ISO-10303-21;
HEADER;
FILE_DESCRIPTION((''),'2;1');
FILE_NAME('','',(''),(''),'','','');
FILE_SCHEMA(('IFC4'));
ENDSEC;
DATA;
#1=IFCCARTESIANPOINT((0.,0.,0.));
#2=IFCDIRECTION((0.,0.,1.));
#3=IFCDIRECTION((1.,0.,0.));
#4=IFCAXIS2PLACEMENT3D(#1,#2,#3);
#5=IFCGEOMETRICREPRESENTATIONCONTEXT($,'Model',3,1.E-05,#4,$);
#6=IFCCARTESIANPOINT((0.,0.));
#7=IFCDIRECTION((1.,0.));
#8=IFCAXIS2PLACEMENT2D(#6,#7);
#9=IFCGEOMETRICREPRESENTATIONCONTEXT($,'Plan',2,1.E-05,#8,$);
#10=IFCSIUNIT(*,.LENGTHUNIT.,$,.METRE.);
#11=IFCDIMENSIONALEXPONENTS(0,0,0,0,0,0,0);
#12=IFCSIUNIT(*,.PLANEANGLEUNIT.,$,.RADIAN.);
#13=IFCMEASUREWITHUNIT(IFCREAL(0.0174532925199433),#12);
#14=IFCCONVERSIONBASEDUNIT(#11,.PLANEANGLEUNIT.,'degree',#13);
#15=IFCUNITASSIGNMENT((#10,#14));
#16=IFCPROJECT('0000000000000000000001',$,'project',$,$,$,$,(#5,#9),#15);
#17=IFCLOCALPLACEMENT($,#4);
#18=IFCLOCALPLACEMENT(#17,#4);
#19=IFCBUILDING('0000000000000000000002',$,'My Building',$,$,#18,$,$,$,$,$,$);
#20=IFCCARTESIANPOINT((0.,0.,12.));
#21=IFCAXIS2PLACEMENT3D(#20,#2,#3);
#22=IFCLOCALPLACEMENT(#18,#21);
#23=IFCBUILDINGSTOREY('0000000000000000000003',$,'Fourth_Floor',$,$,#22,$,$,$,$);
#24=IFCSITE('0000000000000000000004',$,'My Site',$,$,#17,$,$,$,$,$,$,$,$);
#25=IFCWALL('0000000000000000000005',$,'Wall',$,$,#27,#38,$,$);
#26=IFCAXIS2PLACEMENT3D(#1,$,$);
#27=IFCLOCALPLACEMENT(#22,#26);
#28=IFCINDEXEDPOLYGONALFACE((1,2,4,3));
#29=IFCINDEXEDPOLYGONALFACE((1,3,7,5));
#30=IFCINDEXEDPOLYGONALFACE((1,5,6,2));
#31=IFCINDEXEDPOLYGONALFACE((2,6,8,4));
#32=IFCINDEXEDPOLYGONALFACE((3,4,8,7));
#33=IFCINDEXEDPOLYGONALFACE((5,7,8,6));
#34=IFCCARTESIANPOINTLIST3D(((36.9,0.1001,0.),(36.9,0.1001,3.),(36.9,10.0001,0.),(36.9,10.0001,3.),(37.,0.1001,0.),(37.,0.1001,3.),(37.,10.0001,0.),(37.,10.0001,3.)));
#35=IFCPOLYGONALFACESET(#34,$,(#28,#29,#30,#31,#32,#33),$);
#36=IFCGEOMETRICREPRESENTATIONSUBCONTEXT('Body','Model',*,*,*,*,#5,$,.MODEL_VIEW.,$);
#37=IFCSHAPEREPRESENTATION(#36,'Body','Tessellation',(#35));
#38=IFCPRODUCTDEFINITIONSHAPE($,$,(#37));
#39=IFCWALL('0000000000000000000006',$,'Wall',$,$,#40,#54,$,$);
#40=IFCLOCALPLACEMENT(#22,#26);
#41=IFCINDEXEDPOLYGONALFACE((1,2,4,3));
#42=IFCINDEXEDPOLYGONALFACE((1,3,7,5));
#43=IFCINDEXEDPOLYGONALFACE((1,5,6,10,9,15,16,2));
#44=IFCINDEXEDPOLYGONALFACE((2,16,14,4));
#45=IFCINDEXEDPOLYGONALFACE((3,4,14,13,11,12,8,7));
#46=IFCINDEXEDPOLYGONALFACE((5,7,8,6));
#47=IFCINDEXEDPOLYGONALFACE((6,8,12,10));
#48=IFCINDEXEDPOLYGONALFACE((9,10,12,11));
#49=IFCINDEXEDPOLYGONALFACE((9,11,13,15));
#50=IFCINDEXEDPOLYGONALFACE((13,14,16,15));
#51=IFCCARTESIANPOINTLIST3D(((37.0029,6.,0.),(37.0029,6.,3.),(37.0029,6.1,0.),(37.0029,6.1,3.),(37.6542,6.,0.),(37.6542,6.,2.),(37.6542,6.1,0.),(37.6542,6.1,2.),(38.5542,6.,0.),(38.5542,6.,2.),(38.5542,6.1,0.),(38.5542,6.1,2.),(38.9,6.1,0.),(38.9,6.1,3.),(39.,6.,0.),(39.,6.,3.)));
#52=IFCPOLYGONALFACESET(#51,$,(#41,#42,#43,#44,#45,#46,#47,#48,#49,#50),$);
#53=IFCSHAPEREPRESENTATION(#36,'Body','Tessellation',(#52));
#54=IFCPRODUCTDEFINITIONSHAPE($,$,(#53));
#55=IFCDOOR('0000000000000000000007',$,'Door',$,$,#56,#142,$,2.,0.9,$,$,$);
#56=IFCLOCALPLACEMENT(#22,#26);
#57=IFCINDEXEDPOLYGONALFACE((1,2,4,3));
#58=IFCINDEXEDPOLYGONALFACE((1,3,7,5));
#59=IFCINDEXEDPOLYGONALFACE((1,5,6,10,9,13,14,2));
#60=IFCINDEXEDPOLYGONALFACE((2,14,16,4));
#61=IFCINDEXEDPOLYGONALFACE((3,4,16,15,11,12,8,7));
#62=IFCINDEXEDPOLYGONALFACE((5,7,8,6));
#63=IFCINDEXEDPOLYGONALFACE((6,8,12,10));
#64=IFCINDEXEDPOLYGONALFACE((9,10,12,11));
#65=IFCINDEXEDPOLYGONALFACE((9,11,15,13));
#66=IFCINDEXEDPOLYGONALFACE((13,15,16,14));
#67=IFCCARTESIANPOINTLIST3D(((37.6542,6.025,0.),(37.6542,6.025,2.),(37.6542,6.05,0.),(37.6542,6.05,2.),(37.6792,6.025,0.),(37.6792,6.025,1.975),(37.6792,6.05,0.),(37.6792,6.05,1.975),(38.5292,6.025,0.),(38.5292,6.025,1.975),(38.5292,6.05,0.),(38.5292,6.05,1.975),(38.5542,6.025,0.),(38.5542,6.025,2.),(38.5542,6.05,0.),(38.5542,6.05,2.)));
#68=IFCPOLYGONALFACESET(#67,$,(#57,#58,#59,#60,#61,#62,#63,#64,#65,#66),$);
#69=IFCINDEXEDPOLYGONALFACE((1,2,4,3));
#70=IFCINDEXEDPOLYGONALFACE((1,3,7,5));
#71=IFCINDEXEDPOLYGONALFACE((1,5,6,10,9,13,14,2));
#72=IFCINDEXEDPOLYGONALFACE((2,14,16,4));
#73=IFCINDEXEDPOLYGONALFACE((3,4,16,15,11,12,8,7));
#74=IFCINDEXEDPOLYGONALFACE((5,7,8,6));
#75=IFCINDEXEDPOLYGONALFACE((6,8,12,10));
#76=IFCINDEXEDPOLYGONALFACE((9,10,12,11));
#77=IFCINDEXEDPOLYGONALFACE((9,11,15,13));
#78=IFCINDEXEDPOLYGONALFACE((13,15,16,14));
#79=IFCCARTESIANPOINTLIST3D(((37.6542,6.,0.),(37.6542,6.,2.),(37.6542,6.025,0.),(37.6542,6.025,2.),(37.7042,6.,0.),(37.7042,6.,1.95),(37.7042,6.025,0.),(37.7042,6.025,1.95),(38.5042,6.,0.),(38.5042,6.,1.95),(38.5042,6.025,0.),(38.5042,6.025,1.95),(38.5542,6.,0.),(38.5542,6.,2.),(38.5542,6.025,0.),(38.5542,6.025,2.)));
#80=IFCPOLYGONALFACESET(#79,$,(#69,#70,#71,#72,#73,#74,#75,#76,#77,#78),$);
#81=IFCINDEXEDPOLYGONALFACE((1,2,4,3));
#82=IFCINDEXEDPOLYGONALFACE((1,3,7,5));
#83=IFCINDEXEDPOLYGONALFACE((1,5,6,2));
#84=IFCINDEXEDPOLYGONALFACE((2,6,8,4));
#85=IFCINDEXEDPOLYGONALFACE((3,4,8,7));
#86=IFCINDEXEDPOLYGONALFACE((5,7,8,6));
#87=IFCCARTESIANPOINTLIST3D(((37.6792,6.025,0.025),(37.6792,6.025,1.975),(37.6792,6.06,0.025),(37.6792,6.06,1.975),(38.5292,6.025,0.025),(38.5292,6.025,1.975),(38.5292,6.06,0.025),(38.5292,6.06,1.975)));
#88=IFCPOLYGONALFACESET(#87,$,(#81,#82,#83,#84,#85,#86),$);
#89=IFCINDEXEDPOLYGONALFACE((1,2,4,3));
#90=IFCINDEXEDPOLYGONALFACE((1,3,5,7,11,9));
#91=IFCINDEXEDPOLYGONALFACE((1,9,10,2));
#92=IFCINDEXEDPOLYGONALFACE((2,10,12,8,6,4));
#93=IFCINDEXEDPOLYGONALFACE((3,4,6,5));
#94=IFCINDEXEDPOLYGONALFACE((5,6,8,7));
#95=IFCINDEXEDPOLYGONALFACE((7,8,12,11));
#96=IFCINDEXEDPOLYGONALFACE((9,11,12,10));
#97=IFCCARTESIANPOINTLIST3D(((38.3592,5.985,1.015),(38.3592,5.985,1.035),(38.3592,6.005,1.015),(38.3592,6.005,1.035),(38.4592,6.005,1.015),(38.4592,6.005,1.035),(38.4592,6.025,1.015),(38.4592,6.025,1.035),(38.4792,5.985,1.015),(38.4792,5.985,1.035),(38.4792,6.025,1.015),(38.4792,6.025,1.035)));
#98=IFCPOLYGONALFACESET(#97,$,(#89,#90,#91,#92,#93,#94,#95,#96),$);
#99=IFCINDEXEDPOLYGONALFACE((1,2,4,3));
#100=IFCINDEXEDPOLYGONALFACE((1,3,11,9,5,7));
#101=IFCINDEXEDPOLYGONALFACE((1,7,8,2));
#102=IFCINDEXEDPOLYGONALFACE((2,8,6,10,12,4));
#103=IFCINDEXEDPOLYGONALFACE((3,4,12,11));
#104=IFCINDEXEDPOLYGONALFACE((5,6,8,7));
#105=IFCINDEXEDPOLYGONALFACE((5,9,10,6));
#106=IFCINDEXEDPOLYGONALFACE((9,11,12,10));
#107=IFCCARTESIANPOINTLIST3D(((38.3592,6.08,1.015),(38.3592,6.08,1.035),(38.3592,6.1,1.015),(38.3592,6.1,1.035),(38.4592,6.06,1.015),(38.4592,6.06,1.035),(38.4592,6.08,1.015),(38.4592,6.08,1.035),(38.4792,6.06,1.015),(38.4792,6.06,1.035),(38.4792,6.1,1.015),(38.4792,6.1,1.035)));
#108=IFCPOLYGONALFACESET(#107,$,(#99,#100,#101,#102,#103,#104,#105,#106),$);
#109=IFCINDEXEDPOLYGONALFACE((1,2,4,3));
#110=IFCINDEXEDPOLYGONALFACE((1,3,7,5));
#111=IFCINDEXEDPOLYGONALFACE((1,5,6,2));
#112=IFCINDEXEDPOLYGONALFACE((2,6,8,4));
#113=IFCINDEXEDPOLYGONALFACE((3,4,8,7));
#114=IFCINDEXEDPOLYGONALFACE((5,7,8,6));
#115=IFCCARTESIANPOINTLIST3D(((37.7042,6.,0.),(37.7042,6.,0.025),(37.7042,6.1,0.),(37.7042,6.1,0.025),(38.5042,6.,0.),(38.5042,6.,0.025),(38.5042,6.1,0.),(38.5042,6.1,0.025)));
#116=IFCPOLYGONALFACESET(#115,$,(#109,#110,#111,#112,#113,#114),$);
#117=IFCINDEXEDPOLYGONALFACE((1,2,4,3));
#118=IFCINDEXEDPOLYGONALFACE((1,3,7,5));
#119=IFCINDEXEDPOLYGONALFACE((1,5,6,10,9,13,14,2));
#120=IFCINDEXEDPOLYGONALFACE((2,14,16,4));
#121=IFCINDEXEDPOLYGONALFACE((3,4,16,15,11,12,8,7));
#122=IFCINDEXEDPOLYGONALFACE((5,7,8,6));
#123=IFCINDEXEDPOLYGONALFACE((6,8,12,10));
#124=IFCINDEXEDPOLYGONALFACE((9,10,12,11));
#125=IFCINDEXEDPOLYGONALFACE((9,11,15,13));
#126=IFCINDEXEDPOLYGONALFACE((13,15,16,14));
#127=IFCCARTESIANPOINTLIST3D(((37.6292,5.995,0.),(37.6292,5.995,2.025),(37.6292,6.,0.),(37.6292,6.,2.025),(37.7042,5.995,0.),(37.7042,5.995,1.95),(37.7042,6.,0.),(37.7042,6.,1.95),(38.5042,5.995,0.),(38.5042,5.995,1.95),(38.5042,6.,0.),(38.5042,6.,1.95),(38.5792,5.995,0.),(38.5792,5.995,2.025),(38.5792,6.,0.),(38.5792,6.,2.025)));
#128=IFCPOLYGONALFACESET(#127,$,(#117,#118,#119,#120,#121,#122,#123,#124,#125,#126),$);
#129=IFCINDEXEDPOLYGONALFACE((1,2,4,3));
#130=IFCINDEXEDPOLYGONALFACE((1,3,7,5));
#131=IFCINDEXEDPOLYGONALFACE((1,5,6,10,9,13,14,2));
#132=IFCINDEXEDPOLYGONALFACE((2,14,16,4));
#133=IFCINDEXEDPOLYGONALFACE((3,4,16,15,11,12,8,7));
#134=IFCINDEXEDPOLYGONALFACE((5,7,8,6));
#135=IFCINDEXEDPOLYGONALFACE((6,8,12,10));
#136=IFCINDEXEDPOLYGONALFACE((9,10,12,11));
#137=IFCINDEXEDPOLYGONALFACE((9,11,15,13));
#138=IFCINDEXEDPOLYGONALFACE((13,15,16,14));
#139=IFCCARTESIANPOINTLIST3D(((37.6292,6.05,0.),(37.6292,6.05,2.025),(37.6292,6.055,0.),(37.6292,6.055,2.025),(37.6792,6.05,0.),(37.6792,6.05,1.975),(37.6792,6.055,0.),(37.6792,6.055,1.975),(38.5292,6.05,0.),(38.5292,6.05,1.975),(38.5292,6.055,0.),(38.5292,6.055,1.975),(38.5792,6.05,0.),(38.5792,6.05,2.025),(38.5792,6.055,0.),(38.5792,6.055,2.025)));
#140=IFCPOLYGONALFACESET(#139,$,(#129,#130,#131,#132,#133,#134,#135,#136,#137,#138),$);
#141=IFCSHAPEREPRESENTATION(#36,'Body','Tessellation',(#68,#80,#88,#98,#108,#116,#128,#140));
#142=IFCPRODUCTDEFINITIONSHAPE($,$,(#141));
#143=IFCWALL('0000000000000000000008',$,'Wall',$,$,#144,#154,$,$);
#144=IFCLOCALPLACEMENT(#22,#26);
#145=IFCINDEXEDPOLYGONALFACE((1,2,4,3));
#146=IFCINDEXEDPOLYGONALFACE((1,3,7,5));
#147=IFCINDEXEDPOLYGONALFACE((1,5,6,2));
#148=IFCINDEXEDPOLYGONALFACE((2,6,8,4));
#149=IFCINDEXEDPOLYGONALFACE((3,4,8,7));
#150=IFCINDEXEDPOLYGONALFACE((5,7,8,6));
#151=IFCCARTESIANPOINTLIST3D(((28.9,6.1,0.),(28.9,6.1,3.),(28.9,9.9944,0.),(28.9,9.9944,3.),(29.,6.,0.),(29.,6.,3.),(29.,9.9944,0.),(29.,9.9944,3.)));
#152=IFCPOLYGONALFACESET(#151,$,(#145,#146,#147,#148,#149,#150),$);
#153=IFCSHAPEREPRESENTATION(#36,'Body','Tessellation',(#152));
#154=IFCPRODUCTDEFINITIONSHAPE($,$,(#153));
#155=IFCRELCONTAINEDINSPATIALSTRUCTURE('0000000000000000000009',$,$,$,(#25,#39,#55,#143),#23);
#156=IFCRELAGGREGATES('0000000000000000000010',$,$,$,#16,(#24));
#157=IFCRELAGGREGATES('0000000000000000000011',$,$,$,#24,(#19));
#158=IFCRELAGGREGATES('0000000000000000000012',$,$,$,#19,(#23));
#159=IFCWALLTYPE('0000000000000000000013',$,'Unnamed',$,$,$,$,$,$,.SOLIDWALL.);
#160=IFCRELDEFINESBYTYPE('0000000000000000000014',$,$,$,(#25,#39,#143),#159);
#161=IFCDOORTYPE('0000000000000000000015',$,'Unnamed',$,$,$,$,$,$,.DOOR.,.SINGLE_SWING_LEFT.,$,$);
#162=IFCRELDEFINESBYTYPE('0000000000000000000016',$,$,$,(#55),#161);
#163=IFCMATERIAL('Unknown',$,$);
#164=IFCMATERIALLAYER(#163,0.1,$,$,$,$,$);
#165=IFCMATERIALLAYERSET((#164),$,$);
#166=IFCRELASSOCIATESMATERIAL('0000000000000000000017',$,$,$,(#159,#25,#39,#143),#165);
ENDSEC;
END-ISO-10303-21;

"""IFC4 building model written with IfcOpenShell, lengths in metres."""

from ifc_helpers import new_model, entity, si_unit, converted_unit, frame, origin_with_axes, origin_2d_with_axis, place, context, subcontext, project, spatial, line, indexed_curve, outline, extrude, shape, source, transform, mapped, material, layer, layer_set, layer_usage, type_object, type_shapes, element, fill, save


model = new_model("IFC4")

# Units and contexts
model_context = context("Model", 3, precision=1e-05, world=origin_with_axes())
plan_context = context("Plan", 2, precision=1e-05, world=origin_2d_with_axis())
body_context_1 = subcontext(model_context, "Body", "Model", "MODEL_VIEW")
body_context_2 = subcontext(plan_context, "Body", "Plan", "PLAN_VIEW")
ifc_project = project(units=[si_unit("LENGTHUNIT", "METRE"), converted_unit("PLANEANGLEUNIT", "degree", entity("IfcReal", 0.0174532925199433), si_unit("PLANEANGLEUNIT", "RADIAN"), dimensions=[0, 0, 0, 0, 0, 0, 0])], contexts=[model_context, plan_context])

# Site, building, storey
site_placement = place(None, origin_with_axes())
site = spatial("IfcSite", under=ifc_project, at=site_placement, Name="My Site")
building_placement = place(site_placement, origin_with_axes())
building = spatial("IfcBuilding", under=site, at=building_placement, Name="My Building")
storey_placement = place(building_placement, frame((0.0, 0.0, 12.0), z_axis=(0.0, 0.0, 1.0), x_axis=(1.0, 0.0, 0.0)))
storey = spatial("IfcBuildingStorey", under=building, at=storey_placement, Name="Fourth_Floor")

# Shared definitions
ifc_material = material(Name="Unknown")
ifc_layer = layer(ifc_material, 0.1)
ifc_layer_set = layer_set([ifc_layer])
wall_type = type_object("IfcWallType", Name="Unnamed", PredefinedType="SOLIDWALL", material=ifc_layer_set)

# Shared definitions
shared_shape_1 = source(origin_with_axes(), body_context_1, "Body", "SweptSolid", [
    extrude(outline(indexed_curve([(0.0, 0.0), (0.9, 0.0), (0.9, 2.0), (0.0, 2.0)], segments=[line(1, 2, 3, 4, 1)])), frame((0.0, -0.6, 0.0), z_axis=(0.0, -1.0, 0.0), x_axis=(1.0, 0.0, 0.0)), (0.0, 0.0, -1.0), 1.2),
])
door_type = type_object("IfcDoorType", Name="Unnamed", OperationType="SINGLE_SWING_LEFT", PredefinedType="DOOR")
shared_shape_2 = source(origin_with_axes(), body_context_1, "Body", "SweptSolid", [
    extrude(outline(indexed_curve([(0.0, 0.0), (0.0, 2.0), (0.9, 2.0), (0.9, 0.0), (0.875, 0.0), (0.875, 1.975), (0.025, 1.975), (0.025, 0.0)], segments=[line(1, 2, 3, 4, 5, 6, 7, 8, 1)])), frame((0.0, 0.025, 0.0), z_axis=(0.0, -1.0, 0.0), x_axis=(1.0, 0.0, 0.0)), (0.0, 0.0, -1.0), 0.025),
    extrude(outline(indexed_curve([(0.0, 0.0), (0.0, 2.0), (0.9, 2.0), (0.9, 0.0), (0.85, 0.0), (0.85, 1.95), (0.05, 1.95), (0.05, 0.0)], segments=[line(1, 2, 3, 4, 5, 6, 7, 8, 1)])), frame((0.0, 0.0, 0.0), z_axis=(0.0, -1.0, 0.0), x_axis=(1.0, 0.0, 0.0)), (0.0, 0.0, -1.0), 0.025),
    extrude(outline(indexed_curve([(0.0, 0.0), (0.85, 0.0), (0.85, 0.035), (0.0, 0.035)], segments=[line(1, 2, 3, 4, 1)])), frame((0.025, 0.025, 0.025), z_axis=(0.0, 0.0, 1.0), x_axis=(1.0, 0.0, 0.0)), (0.0, 0.0, 1.0), 1.95),
    extrude(outline(indexed_curve([(0.0, 0.0), (0.0, -0.04), (-0.12, -0.04), (-0.12, -0.02), (-0.02, -0.02), (-0.02, 0.0)], segments=[line(1, 2, 3, 4, 5, 6, 1)])), frame((0.825, 0.025, 1.015), z_axis=(0.0, 0.0, 1.0), x_axis=(1.0, 0.0, 0.0)), (0.0, 0.0, 1.0), 0.02),
    extrude(outline(indexed_curve([(0.0, 0.0), (0.0, 0.04), (-0.12, 0.04), (-0.12, 0.02), (-0.02, 0.02), (-0.02, 0.0)], segments=[line(1, 2, 3, 4, 5, 6, 1)])), frame((0.825, 0.06, 1.015), z_axis=(0.0, 0.0, 1.0), x_axis=(1.0, 0.0, 0.0)), (0.0, 0.0, 1.0), 0.02),
    extrude(outline(indexed_curve([(0.0, 0.0), (0.8, 0.0), (0.8, 0.1), (0.0, 0.1)], segments=[line(1, 2, 3, 4, 1)])), frame((0.05, 0.0, 0.0), z_axis=(0.0, 0.0, 1.0), x_axis=(1.0, 0.0, 0.0)), (0.0, 0.0, 1.0), 0.025),
    extrude(outline(indexed_curve([(0.0, 0.0), (0.0, 2.025), (0.95, 2.025), (0.95, 0.0), (0.875, 0.0), (0.875, 1.95), (0.075, 1.95), (0.075, 0.0)], segments=[line(1, 2, 3, 4, 5, 6, 7, 8, 1)])), frame((-0.025, -0.005, 0.0), z_axis=(0.0, -1.0, 0.0), x_axis=(1.0, 0.0, 0.0)), (0.0, 0.0, -1.0), 0.005),
    extrude(outline(indexed_curve([(0.0, 0.0), (0.0, 2.025), (0.95, 2.025), (0.95, 0.0), (0.9, 0.0), (0.9, 1.975), (0.05, 1.975), (0.05, 0.0)], segments=[line(1, 2, 3, 4, 5, 6, 7, 8, 1)])), frame((-0.025, 0.05, 0.0), z_axis=(0.0, -1.0, 0.0), x_axis=(1.0, 0.0, 0.0)), (0.0, 0.0, -1.0), 0.005),
])
shared_shape_3 = source(origin_with_axes(), body_context_2, "Body", "Curve2D", [
    entity("IfcIndexedPolyCurve", entity("IfcCartesianPointList2D", [[0.0, 0.0], [0.0, 0.05], [0.025, 0.05], [0.025, 0.025], [0.05, 0.025], [0.05, 0.0]]), [entity("IfcLineIndex", [1, 2, 3, 4, 5, 6, 1])]),
    entity("IfcIndexedPolyCurve", entity("IfcCartesianPointList2D", [[0.9, 0.0], [0.9, 0.05], [0.875, 0.05], [0.875, 0.025], [0.85, 0.025], [0.85, 0.0]]), [entity("IfcLineIndex", [1, 2, 3, 4, 5, 6, 1])]),
    entity("IfcTrimmedCurve", entity("IfcEllipse", entity("IfcAxis2Placement2D", entity("IfcCartesianPoint", [0.06, 0.05]), entity("IfcDirection", [1.0, 0.0])), 0.815, 0.85), [entity("IfcCartesianPoint", [0.875, 0.05])], [entity("IfcCartesianPoint", [0.06, 0.9])], True, "CARTESIAN"),
    entity("IfcIndexedPolyCurve", entity("IfcCartesianPointList2D", [[0.025, 0.05], [0.06, 0.05], [0.06, 0.9], [0.025, 0.9]]), [entity("IfcLineIndex", [1, 2, 3, 4, 1])]),
])
type_shapes(door_type, [shared_shape_2, shared_shape_3])

# Wall
ifc_layer_usage_1 = layer_usage(ifc_layer_set, "AXIS2", "POSITIVE", 0.0)
wall_1_placement = place(storey_placement, frame((36.9, 10.0001, 0.0), z_axis=(0.0, 0.0, 1.0), x_axis=(0.0, -1.0, 0.0)))
element("IfcWall", 1, at=wall_1_placement, inside=storey, type_object=wall_type, material=ifc_layer_usage_1, Name="Wall", context=body_context_1, shape_type="SweptSolid", body=[
    extrude(outline(indexed_curve([(0.0, 0.0), (0.0, 0.1), (9.9, 0.1), (9.9, 0.0)], segments=[line(1, 2, 3, 4, 1)])), origin_with_axes(), (0.0, 0.0, 1.0), 3.0),
])

# Wall, opening, door
ifc_layer_usage_2 = layer_usage(ifc_layer_set, "AXIS2", "POSITIVE", 0.0)
wall_2_placement = place(storey_placement, frame((37.0029, 6.0, 0.0), z_axis=(0.0, 0.0, 1.0), x_axis=(1.0, 0.0, 0.0)))
wall_2 = element("IfcWall", 2, at=wall_2_placement, inside=storey, type_object=wall_type, material=ifc_layer_usage_2, Name="Wall", context=body_context_1, shape_type="SweptSolid", body=[
    extrude(outline(indexed_curve([(0.0, 0.0), (0.0, 0.1), (1.8971, 0.1), (1.9971, 0.0)], segments=[line(1, 2, 3, 4, 1)])), origin_with_axes(), (0.0, 0.0, 1.0), 3.0),
])
opening_1_placement = place(wall_2_placement, frame((0.6513, 0.0, 0.0), z_axis=(0.0, 0.0, 1.0), x_axis=(1.0, 0.0, 0.0)))
opening_1 = element("IfcOpeningElement", 3, at=opening_1_placement, cuts=wall_2, PredefinedType="OPENING", context=body_context_1, shape_type="MappedRepresentation", body=[
    mapped(shared_shape_1, transform((0.0, 0.0, 0.0), x_axis=(1.0, 0.0, 0.0), y_axis=(0.0, 1.0, 0.0), z_axis=(0.0, 0.0, 1.0), scale=1.0)),
])
door_1_placement = place(opening_1_placement, origin_with_axes())
door_1 = element("IfcDoor", 4, at=door_1_placement, inside=storey, type_object=door_type, Name="Door", OverallHeight=2.0, OverallWidth=0.9, shapes=[
    shape(body_context_1, "Body", "MappedRepresentation", [mapped(shared_shape_2, transform((0.0, 0.0, 0.0), x_axis=(1.0, 0.0, 0.0), y_axis=(0.0, 1.0, 0.0), z_axis=(0.0, 0.0, 1.0), scale=1.0))]),
    shape(body_context_2, "Body", "MappedRepresentation", [mapped(shared_shape_3, transform((0.0, 0.0, 0.0), x_axis=(1.0, 0.0, 0.0), y_axis=(0.0, 1.0, 0.0), z_axis=(0.0, 0.0, 1.0), scale=1.0))]),
])
fill(opening_1, door_1)

# Wall
ifc_layer_usage_3 = layer_usage(ifc_layer_set, "AXIS2", "POSITIVE", 0.0)
wall_3_placement = place(storey_placement, frame((29.0, 6.0, 0.0), z_axis=(0.0, 0.0, 1.0), x_axis=(0.0, 1.0, 0.0)))
element("IfcWall", 5, at=wall_3_placement, inside=storey, type_object=wall_type, material=ifc_layer_usage_3, Name="Wall", context=body_context_1, shape_type="SweptSolid", body=[
    extrude(outline(indexed_curve([(0.0, 0.0), (0.1, 0.1), (3.9944, 0.1), (3.9944, 0.0)], segments=[line(1, 2, 3, 4, 1)])), origin_with_axes(), (0.0, 0.0, 1.0), 3.0),
])

save(model, "model.ifc")
